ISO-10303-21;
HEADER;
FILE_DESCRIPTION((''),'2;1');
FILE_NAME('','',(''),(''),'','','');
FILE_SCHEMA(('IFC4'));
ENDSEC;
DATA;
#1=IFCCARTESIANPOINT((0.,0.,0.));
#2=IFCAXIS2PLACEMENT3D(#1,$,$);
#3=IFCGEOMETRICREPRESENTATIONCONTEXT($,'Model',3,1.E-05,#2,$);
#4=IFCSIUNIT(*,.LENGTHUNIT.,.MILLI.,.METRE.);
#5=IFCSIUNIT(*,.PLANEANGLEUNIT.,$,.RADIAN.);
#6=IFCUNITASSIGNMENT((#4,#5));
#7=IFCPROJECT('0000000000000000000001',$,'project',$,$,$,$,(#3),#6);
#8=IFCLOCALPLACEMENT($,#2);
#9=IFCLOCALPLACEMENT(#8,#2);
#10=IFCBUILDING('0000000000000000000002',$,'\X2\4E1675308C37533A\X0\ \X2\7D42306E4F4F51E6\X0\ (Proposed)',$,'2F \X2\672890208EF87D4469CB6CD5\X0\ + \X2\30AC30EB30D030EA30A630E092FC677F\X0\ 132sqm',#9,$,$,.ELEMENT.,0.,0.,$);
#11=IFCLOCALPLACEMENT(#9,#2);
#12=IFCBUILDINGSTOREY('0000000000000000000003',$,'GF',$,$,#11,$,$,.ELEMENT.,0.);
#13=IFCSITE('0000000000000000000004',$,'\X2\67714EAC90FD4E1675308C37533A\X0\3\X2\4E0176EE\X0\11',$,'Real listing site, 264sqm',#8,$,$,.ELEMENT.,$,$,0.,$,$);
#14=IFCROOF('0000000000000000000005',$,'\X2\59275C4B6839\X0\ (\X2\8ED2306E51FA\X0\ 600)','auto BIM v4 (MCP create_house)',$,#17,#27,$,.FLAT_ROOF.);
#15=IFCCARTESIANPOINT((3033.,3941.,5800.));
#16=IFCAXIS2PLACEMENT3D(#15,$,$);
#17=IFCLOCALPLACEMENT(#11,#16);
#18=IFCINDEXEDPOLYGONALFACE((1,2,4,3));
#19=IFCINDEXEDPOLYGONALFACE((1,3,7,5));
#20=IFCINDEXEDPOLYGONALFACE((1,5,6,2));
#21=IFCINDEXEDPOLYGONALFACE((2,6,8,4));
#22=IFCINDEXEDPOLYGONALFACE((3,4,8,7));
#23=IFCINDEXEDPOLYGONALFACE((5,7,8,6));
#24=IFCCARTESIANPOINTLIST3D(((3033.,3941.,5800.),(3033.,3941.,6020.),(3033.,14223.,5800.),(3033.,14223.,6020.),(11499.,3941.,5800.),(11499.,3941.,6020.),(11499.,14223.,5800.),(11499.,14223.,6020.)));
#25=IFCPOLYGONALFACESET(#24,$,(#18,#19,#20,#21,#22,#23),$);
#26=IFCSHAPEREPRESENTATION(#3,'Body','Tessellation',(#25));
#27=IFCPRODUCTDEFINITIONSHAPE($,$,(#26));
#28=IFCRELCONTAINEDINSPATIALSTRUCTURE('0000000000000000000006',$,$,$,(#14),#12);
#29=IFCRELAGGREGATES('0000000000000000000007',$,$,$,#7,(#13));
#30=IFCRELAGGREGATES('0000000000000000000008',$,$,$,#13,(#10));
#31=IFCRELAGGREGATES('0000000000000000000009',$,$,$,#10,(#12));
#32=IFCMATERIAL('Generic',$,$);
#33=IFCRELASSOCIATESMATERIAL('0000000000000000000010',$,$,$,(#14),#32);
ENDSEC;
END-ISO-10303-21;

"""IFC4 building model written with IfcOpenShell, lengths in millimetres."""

from ifc_helpers import new_model, si_unit, frame, frame_2d, origin, place, context, project, spatial, rectangle, extrude, material, element, save


model = new_model("IFC4")

# Units and contexts
model_context = context("Model", 3, precision=1e-05, world=origin())
ifc_project = project(units=[si_unit("LENGTHUNIT", "METRE", prefix="MILLI"), si_unit("PLANEANGLEUNIT", "RADIAN")], contexts=[model_context])

# Site, building, storey
site_placement = place(None, origin())
site = spatial("IfcSite", under=ifc_project, at=site_placement, Name="東京都世田谷区3丁目11", ObjectType="Real listing site, 264sqm", CompositionType="ELEMENT", RefElevation=0.0)
building_placement = place(site_placement, origin())
building = spatial("IfcBuilding", under=site, at=building_placement, Name="世田谷区 終の住処 (Proposed)", ObjectType="2F 木造軸組構法 + ガルバリウム鋼板 132sqm", CompositionType="ELEMENT", ElevationOfRefHeight=0.0, ElevationOfTerrain=0.0)
storey_placement = place(building_placement, origin())
storey = spatial("IfcBuildingStorey", under=building, at=storey_placement, Name="GF", CompositionType="ELEMENT", Elevation=0.0)

# Shared definitions
ifc_material = material(Name="Generic")

# Roof
roof_placement = place(storey_placement, frame((3033.0, 3941.0, 5800.0)))
element("IfcRoof", 1, at=roof_placement, inside=storey, material=ifc_material, Name="大屋根 (軒の出 600)", Description="auto BIM v4 (MCP create_house)", PredefinedType="FLAT_ROOF", context=model_context, shape_type="SweptSolid", body=[
    extrude(rectangle(XDim=8466.0, YDim=10282.0, at=frame_2d((4233.0, 5141.0))), frame((3033.0, 3941.0, 5800.0)), (0.0, 0.0, 1.0), 220.0),
])

save(model, "model.ifc")
